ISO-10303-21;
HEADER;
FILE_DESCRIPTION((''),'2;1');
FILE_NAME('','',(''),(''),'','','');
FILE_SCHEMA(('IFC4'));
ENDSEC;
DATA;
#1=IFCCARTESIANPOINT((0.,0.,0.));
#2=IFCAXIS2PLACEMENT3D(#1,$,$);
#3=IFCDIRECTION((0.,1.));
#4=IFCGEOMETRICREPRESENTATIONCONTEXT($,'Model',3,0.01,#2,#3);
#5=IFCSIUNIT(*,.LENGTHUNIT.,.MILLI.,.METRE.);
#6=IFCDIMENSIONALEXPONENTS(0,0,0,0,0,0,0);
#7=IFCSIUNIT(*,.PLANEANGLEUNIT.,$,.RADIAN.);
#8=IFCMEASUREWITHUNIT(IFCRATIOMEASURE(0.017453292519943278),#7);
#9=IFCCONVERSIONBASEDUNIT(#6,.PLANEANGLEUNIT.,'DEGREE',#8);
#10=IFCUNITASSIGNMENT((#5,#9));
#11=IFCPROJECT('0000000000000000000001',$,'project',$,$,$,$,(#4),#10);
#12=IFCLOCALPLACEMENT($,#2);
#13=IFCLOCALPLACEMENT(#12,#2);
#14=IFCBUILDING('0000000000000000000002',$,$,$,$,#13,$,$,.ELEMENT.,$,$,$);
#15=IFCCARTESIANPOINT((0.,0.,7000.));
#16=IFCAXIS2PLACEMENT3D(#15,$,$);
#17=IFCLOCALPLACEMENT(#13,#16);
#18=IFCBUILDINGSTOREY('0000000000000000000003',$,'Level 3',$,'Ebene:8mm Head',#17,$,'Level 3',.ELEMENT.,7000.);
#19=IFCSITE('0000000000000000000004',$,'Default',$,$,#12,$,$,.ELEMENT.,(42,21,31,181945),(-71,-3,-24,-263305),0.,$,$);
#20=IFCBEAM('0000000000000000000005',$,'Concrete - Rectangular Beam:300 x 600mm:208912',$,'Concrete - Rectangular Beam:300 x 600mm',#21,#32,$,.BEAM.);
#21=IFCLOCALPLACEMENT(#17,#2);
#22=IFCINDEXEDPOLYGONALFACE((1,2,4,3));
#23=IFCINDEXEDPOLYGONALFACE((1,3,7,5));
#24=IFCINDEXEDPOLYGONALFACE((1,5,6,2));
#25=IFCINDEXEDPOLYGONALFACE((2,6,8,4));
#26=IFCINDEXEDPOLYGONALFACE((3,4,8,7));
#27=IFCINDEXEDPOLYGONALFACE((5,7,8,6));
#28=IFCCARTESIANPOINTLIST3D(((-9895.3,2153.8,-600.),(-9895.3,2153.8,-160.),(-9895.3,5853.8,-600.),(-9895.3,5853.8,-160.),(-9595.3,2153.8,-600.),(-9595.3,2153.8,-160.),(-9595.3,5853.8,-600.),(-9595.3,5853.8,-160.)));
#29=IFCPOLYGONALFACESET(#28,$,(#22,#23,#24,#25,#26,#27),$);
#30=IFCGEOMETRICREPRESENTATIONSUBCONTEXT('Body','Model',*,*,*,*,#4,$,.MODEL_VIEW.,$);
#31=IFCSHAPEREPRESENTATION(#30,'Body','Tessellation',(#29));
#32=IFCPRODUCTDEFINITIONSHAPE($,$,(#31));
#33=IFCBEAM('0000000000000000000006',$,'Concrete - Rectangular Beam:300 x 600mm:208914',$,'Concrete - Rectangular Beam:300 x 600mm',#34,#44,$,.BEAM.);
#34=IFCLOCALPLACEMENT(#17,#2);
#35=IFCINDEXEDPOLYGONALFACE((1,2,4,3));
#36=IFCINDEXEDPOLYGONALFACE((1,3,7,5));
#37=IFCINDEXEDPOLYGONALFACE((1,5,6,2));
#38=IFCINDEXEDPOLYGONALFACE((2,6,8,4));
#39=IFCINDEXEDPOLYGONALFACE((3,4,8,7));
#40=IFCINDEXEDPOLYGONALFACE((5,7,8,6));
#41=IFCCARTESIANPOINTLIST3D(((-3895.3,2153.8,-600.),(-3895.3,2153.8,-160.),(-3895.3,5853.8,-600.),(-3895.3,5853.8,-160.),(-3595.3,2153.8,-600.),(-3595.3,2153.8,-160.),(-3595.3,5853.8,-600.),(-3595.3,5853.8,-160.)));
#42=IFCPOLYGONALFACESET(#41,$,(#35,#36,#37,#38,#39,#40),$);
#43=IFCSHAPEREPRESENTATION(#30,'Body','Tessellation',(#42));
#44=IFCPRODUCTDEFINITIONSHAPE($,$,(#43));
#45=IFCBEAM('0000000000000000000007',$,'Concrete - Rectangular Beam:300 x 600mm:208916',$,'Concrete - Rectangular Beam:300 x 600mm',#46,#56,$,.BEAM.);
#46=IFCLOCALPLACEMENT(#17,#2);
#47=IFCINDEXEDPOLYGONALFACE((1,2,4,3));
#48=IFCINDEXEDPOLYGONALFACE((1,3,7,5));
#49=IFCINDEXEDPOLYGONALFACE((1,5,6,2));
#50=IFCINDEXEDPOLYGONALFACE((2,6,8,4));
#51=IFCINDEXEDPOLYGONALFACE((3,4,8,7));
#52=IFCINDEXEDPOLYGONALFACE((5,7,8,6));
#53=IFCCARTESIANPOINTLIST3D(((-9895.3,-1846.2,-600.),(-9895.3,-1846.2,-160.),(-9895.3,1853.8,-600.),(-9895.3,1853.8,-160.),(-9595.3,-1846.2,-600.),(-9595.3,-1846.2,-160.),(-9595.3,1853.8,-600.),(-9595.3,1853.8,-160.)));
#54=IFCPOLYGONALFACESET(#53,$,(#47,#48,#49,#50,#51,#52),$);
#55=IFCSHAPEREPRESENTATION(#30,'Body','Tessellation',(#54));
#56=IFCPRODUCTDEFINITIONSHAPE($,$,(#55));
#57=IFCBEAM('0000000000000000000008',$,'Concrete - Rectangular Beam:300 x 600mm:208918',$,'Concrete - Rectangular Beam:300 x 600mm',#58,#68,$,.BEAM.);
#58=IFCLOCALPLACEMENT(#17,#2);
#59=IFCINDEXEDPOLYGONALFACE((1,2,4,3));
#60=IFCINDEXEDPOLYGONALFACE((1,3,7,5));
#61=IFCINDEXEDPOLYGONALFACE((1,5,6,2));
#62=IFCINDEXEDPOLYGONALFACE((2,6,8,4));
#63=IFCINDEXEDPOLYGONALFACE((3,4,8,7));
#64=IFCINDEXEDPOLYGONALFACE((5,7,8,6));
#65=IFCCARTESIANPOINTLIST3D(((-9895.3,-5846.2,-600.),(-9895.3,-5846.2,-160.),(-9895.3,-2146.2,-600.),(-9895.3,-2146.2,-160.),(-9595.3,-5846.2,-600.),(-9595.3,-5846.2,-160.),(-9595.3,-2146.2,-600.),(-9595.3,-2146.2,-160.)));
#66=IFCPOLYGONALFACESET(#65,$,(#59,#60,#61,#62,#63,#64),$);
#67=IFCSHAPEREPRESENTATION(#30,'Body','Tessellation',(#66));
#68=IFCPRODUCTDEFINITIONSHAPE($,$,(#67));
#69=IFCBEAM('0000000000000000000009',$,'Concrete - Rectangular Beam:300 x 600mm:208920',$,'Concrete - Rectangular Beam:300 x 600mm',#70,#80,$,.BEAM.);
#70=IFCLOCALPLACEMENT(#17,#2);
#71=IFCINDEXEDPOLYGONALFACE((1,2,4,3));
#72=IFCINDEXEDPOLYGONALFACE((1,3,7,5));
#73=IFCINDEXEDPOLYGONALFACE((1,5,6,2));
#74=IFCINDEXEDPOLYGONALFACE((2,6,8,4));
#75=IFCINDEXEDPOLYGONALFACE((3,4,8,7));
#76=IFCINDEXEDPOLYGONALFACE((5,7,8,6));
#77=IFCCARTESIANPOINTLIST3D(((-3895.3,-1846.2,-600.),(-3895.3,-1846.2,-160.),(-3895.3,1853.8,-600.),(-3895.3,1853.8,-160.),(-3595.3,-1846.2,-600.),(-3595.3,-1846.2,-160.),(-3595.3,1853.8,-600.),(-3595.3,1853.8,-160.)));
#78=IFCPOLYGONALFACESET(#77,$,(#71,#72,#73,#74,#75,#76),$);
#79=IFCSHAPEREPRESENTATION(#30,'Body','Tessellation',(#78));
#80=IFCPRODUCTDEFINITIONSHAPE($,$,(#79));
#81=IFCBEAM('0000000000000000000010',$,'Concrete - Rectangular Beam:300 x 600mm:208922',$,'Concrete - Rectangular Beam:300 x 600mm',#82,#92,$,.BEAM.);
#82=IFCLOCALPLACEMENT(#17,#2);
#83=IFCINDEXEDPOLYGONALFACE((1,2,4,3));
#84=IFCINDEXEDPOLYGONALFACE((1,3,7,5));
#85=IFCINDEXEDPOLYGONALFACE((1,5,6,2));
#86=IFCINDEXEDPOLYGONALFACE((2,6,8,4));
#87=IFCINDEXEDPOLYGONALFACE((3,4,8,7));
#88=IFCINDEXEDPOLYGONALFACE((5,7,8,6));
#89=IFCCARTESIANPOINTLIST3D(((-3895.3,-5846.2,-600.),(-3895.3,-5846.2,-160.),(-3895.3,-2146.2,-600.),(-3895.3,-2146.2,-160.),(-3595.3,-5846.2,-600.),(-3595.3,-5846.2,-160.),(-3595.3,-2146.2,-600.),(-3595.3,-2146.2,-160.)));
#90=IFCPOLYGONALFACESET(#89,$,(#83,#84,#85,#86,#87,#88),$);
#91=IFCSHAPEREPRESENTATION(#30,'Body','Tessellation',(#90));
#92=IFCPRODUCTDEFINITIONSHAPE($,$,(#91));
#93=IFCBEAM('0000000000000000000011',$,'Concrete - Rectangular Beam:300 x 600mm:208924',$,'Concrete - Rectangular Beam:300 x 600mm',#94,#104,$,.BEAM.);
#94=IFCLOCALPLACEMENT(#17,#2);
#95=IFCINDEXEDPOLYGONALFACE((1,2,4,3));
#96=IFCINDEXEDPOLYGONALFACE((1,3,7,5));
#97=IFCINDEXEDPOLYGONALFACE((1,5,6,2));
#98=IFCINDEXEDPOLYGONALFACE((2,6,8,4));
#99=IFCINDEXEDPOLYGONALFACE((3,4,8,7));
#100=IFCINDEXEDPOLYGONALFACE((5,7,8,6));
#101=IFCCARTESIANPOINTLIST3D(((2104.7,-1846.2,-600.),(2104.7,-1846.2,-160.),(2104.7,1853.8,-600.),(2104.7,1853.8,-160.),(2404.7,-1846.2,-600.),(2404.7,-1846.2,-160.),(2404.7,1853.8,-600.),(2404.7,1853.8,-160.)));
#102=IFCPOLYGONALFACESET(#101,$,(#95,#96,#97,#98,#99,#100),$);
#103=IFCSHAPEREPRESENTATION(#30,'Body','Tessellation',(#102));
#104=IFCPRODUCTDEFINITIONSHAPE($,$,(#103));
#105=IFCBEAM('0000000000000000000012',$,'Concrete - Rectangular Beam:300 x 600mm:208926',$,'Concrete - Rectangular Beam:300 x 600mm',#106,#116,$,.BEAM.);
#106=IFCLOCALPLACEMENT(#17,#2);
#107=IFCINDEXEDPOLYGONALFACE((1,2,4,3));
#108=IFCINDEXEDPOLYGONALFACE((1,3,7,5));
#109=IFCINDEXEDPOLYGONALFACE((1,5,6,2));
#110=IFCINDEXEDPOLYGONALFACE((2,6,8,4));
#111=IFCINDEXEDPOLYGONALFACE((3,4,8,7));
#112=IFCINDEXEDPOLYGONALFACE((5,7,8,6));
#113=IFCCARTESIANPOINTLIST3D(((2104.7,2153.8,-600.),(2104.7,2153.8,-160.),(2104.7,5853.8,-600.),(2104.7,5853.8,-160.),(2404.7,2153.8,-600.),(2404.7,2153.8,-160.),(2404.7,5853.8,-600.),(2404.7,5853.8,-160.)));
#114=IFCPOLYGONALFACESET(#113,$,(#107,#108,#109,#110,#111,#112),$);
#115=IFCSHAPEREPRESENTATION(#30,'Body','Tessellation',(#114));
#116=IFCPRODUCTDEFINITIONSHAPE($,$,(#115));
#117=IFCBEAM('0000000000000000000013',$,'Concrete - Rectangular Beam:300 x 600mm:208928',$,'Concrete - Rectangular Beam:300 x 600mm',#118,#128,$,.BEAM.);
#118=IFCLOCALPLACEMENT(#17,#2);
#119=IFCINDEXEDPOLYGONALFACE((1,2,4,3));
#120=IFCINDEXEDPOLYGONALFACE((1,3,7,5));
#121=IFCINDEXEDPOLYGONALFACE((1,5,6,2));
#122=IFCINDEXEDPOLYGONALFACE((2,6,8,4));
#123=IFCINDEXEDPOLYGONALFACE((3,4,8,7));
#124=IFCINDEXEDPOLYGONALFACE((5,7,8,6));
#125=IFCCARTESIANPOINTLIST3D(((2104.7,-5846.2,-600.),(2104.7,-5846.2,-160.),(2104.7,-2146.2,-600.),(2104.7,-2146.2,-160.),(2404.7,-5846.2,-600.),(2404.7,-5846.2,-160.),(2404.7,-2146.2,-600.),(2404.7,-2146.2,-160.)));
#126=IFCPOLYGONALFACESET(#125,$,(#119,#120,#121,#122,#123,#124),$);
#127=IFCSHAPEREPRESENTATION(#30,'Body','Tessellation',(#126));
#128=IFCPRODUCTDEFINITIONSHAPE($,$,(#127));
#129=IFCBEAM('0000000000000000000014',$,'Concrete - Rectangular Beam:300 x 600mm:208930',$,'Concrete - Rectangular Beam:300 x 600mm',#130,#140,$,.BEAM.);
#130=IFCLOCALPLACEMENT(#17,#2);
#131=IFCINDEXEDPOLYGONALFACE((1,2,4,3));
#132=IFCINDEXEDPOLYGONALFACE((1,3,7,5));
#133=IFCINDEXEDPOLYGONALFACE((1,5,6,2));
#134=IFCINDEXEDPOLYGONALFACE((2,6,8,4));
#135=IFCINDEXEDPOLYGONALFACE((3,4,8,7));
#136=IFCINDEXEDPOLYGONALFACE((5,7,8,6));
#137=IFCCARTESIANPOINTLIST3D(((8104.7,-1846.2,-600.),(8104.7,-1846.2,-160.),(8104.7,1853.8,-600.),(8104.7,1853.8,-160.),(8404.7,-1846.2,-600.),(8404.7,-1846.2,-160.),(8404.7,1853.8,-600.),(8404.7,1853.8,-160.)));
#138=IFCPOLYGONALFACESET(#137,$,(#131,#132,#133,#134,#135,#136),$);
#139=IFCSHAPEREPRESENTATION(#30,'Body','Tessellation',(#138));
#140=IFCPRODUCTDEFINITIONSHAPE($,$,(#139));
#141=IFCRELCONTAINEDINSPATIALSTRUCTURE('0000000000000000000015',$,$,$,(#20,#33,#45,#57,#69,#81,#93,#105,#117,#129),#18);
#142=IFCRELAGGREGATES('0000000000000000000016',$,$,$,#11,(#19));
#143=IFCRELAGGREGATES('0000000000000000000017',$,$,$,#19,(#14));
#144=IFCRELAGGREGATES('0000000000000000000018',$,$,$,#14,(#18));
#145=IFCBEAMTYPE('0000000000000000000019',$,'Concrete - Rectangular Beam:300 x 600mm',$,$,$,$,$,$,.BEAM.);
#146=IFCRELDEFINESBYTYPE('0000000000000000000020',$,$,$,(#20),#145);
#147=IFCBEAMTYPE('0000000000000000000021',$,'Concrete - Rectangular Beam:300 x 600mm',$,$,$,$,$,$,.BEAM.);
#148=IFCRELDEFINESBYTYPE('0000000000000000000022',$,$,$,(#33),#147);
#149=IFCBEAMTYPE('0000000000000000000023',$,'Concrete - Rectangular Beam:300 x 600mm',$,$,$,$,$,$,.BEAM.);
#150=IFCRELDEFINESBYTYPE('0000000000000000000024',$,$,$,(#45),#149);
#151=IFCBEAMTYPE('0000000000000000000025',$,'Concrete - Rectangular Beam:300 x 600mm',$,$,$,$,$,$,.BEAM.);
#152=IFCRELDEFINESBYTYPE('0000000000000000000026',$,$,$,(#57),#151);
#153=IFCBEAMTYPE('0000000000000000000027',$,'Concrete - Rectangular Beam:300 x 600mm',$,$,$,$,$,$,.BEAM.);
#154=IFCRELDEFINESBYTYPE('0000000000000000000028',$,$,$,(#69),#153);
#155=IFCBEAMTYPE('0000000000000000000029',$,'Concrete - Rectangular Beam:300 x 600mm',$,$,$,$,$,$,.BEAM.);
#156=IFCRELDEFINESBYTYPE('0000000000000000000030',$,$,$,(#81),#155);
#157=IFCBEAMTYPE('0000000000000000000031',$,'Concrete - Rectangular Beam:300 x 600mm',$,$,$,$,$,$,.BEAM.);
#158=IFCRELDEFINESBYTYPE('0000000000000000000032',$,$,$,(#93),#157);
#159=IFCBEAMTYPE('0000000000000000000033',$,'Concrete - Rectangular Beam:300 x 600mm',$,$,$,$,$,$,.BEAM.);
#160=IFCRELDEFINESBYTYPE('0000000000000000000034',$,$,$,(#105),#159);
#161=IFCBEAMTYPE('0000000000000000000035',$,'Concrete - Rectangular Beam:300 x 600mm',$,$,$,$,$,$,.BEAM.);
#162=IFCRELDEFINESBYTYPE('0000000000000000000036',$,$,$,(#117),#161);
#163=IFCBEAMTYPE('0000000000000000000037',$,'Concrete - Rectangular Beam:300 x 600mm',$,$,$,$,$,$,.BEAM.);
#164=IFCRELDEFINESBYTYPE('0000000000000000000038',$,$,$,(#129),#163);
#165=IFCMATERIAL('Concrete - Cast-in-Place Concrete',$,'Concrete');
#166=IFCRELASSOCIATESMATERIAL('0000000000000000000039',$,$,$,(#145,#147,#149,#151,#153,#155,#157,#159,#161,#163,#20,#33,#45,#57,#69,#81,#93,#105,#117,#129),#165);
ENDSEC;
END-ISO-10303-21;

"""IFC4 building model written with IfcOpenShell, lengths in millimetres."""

from ifc_helpers import new_model, entity, si_unit, converted_unit, direction, frame, frame_2d, origin, place, context, subcontext, project, spatial, polyline, segment, composite_curve, rectangle, outline, extrude, source, transform, mapped, material, material_profile, profile_set, profile_usage, type_object, type_shapes, element, save


model = new_model("IFC4")

# Units and contexts
model_context = context("Model", 3, precision=0.01, world=origin(), true_north=direction((0.0, 1.0)))
body_context = subcontext(model_context, "Body", "Model", "MODEL_VIEW")
ifc_project = project(units=[si_unit("LENGTHUNIT", "METRE", prefix="MILLI"), converted_unit("PLANEANGLEUNIT", "DEGREE", entity("IfcRatioMeasure", 0.017453292519943278), si_unit("PLANEANGLEUNIT", "RADIAN"), dimensions=[0, 0, 0, 0, 0, 0, 0])], contexts=[model_context])

# Site, building, storey
site_placement = place(None, origin())
site = spatial("IfcSite", under=ifc_project, at=site_placement, Name="Default", CompositionType="ELEMENT", RefLatitude=(42, 21, 31, 181945), RefLongitude=(-71, -3, -24, -263305), RefElevation=0.0)
building_placement = place(site_placement, origin())
building = spatial("IfcBuilding", under=site, at=building_placement, CompositionType="ELEMENT")
storey_placement = place(building_placement, frame((0.0, 0.0, 7000.0)))
storey = spatial("IfcBuildingStorey", under=building, at=storey_placement, Name="Level 3", ObjectType="Ebene:8mm Head", LongName="Level 3", CompositionType="ELEMENT", Elevation=7000.0)

# Beams
ifc_material_1 = material(Name="Concrete - Cast-in-Place Concrete", Category="Concrete")
ifc_material_profile_1 = material_profile(ifc_material_1, outline(composite_curve([segment(polyline([(-150.0, -300.0, 0.0), (-150.0, 140.0, 0.0)]), True, "CONTINUOUS"), segment(polyline([(-150.0, 140.0, 0.0), (150.0, 140.0, 0.0)]), True, "CONTINUOUS"), segment(polyline([(150.0, 140.0, 0.0), (150.0, -300.0, 0.0)]), True, "CONTINUOUS"), segment(polyline([(150.0, -300.0, 0.0), (-150.0, -300.0, 0.0)]), True, "CONTINUOUS")], self_intersect=False), kind="CURVE"), Name="300 x 600mm")
ifc_material_profile_2 = material_profile(ifc_material_1, outline(composite_curve([segment(polyline([(1850.0, -150.0, -300.0), (1850.0, -150.0, 300.0)]), True, "CONTINUOUS"), segment(polyline([(1850.0, -150.0, 300.0), (-1850.0, -150.0, 300.0)]), True, "CONTINUOUS"), segment(polyline([(-1850.0, -150.0, 300.0), (-1850.0, -150.0, -300.0)]), True, "CONTINUOUS"), segment(polyline([(-1850.0, -150.0, -300.0), (1850.0, -150.0, -300.0)]), True, "CONTINUOUS")], self_intersect=False), kind="CURVE"), Name="300 x 600mm")
ifc_profile_set = profile_set([ifc_material_profile_1, ifc_material_profile_2], Name="300 x 600mm")
ifc_profile_usage_1 = profile_usage(ifc_profile_set, cardinal=8)
beam_type_1 = type_object("IfcBeamType", Name="Concrete - Rectangular Beam:300 x 600mm", PredefinedType="BEAM", material=ifc_profile_set)
shared_shape_1 = source(origin(), body_context, "Body", "SweptSolid", [
    extrude(rectangle(XDim=440.0, YDim=300.0, at=frame_2d((0.0, 0.0), x_axis=(0.0, 1.0))), frame((-9745.3, 5853.8, 6620.0), z_axis=(0.0, -1.0, 0.0), x_axis=(-1.0, 0.0, 0.0)), (0.0, 0.0, 1.0), 3700.0),
])
type_shapes(beam_type_1, [shared_shape_1])
beam_1_placement = place(storey_placement, frame((0.0, 0.0, -7000.0)))
element("IfcBeam", 1, at=beam_1_placement, inside=storey, type_object=beam_type_1, material=ifc_profile_usage_1, Name="Concrete - Rectangular Beam:300 x 600mm:208912", ObjectType="Concrete - Rectangular Beam:300 x 600mm", PredefinedType="BEAM", context=body_context, shape_type="MappedRepresentation", body=[
    mapped(shared_shape_1, transform((0.0, 0.0, 0.0), scale=1.0)),
])
ifc_profile_usage_2 = profile_usage(ifc_profile_set, cardinal=8)
beam_type_2 = type_object("IfcBeamType", Name="Concrete - Rectangular Beam:300 x 600mm", PredefinedType="BEAM", material=ifc_profile_set)
shared_shape_2 = source(origin(), body_context, "Body", "SweptSolid", [
    extrude(rectangle(XDim=440.0, YDim=300.0, at=frame_2d((0.0, 0.0), x_axis=(0.0, 1.0))), frame((-3745.3, 5853.8, 6620.0), z_axis=(0.0, -1.0, 0.0), x_axis=(-1.0, 0.0, 0.0)), (0.0, 0.0, 1.0), 3700.0),
])
type_shapes(beam_type_2, [shared_shape_2])
beam_2_placement = place(storey_placement, frame((0.0, 0.0, -7000.0)))
element("IfcBeam", 2, at=beam_2_placement, inside=storey, type_object=beam_type_2, material=ifc_profile_usage_2, Name="Concrete - Rectangular Beam:300 x 600mm:208914", ObjectType="Concrete - Rectangular Beam:300 x 600mm", PredefinedType="BEAM", context=body_context, shape_type="MappedRepresentation", body=[
    mapped(shared_shape_2, transform((0.0, 0.0, 0.0), scale=1.0)),
])
ifc_profile_usage_3 = profile_usage(ifc_profile_set, cardinal=8)
beam_type_3 = type_object("IfcBeamType", Name="Concrete - Rectangular Beam:300 x 600mm", PredefinedType="BEAM", material=ifc_profile_set)
shared_shape_3 = source(origin(), body_context, "Body", "SweptSolid", [
    extrude(rectangle(XDim=440.0, YDim=300.0, at=frame_2d((0.0, 0.0), x_axis=(0.0, 1.0))), frame((-9745.3, 1853.8, 6620.0), z_axis=(0.0, -1.0, 0.0), x_axis=(-1.0, 0.0, 0.0)), (0.0, 0.0, 1.0), 3700.0),
])
type_shapes(beam_type_3, [shared_shape_3])
beam_3_placement = place(storey_placement, frame((0.0, 0.0, -7000.0)))
element("IfcBeam", 3, at=beam_3_placement, inside=storey, type_object=beam_type_3, material=ifc_profile_usage_3, Name="Concrete - Rectangular Beam:300 x 600mm:208916", ObjectType="Concrete - Rectangular Beam:300 x 600mm", PredefinedType="BEAM", context=body_context, shape_type="MappedRepresentation", body=[
    mapped(shared_shape_3, transform((0.0, 0.0, 0.0), scale=1.0)),
])
ifc_profile_usage_4 = profile_usage(ifc_profile_set, cardinal=8)
beam_type_4 = type_object("IfcBeamType", Name="Concrete - Rectangular Beam:300 x 600mm", PredefinedType="BEAM", material=ifc_profile_set)
shared_shape_4 = source(origin(), body_context, "Body", "SweptSolid", [
    extrude(rectangle(XDim=440.0, YDim=300.0, at=frame_2d((0.0, 0.0), x_axis=(0.0, 1.0))), frame((-9745.3, -2146.2, 6620.0), z_axis=(0.0, -1.0, 0.0), x_axis=(-1.0, 0.0, 0.0)), (0.0, 0.0, 1.0), 3700.0),
])
type_shapes(beam_type_4, [shared_shape_4])
beam_4_placement = place(storey_placement, frame((0.0, 0.0, -7000.0)))
element("IfcBeam", 4, at=beam_4_placement, inside=storey, type_object=beam_type_4, material=ifc_profile_usage_4, Name="Concrete - Rectangular Beam:300 x 600mm:208918", ObjectType="Concrete - Rectangular Beam:300 x 600mm", PredefinedType="BEAM", context=body_context, shape_type="MappedRepresentation", body=[
    mapped(shared_shape_4, transform((0.0, 0.0, 0.0), scale=1.0)),
])
ifc_profile_usage_5 = profile_usage(ifc_profile_set, cardinal=8)
beam_type_5 = type_object("IfcBeamType", Name="Concrete - Rectangular Beam:300 x 600mm", PredefinedType="BEAM", material=ifc_profile_set)
shared_shape_5 = source(origin(), body_context, "Body", "SweptSolid", [
    extrude(rectangle(XDim=440.0, YDim=300.0, at=frame_2d((0.0, 0.0), x_axis=(0.0, 1.0))), frame((-3745.3, 1853.8, 6620.0), z_axis=(0.0, -1.0, 0.0), x_axis=(-1.0, 0.0, 0.0)), (0.0, 0.0, 1.0), 3700.0),
])
type_shapes(beam_type_5, [shared_shape_5])
beam_5_placement = place(storey_placement, frame((0.0, 0.0, -7000.0)))
element("IfcBeam", 5, at=beam_5_placement, inside=storey, type_object=beam_type_5, material=ifc_profile_usage_5, Name="Concrete - Rectangular Beam:300 x 600mm:208920", ObjectType="Concrete - Rectangular Beam:300 x 600mm", PredefinedType="BEAM", context=body_context, shape_type="MappedRepresentation", body=[
    mapped(shared_shape_5, transform((0.0, 0.0, 0.0), scale=1.0)),
])
ifc_profile_usage_6 = profile_usage(ifc_profile_set, cardinal=8)
beam_type_6 = type_object("IfcBeamType", Name="Concrete - Rectangular Beam:300 x 600mm", PredefinedType="BEAM", material=ifc_profile_set)
shared_shape_6 = source(origin(), body_context, "Body", "SweptSolid", [
    extrude(rectangle(XDim=440.0, YDim=300.0, at=frame_2d((0.0, 0.0), x_axis=(0.0, 1.0))), frame((-3745.3, -2146.2, 6620.0), z_axis=(0.0, -1.0, 0.0), x_axis=(-1.0, 0.0, 0.0)), (0.0, 0.0, 1.0), 3700.0),
])
type_shapes(beam_type_6, [shared_shape_6])
beam_6_placement = place(storey_placement, frame((0.0, 0.0, -7000.0)))
element("IfcBeam", 6, at=beam_6_placement, inside=storey, type_object=beam_type_6, material=ifc_profile_usage_6, Name="Concrete - Rectangular Beam:300 x 600mm:208922", ObjectType="Concrete - Rectangular Beam:300 x 600mm", PredefinedType="BEAM", context=body_context, shape_type="MappedRepresentation", body=[
    mapped(shared_shape_6, transform((0.0, 0.0, 0.0), scale=1.0)),
])
ifc_profile_usage_7 = profile_usage(ifc_profile_set, cardinal=8)
beam_type_7 = type_object("IfcBeamType", Name="Concrete - Rectangular Beam:300 x 600mm", PredefinedType="BEAM", material=ifc_profile_set)
shared_shape_7 = source(origin(), body_context, "Body", "SweptSolid", [
    extrude(rectangle(XDim=440.0, YDim=300.0, at=frame_2d((0.0, 0.0), x_axis=(0.0, 1.0))), frame((2254.7, 1853.8, 6620.0), z_axis=(0.0, -1.0, 0.0), x_axis=(-1.0, 0.0, 0.0)), (0.0, 0.0, 1.0), 3700.0),
])
type_shapes(beam_type_7, [shared_shape_7])
beam_7_placement = place(storey_placement, frame((0.0, 0.0, -7000.0)))
element("IfcBeam", 7, at=beam_7_placement, inside=storey, type_object=beam_type_7, material=ifc_profile_usage_7, Name="Concrete - Rectangular Beam:300 x 600mm:208924", ObjectType="Concrete - Rectangular Beam:300 x 600mm", PredefinedType="BEAM", context=body_context, shape_type="MappedRepresentation", body=[
    mapped(shared_shape_7, transform((0.0, 0.0, 0.0), scale=1.0)),
])
ifc_profile_usage_8 = profile_usage(ifc_profile_set, cardinal=8)
beam_type_8 = type_object("IfcBeamType", Name="Concrete - Rectangular Beam:300 x 600mm", PredefinedType="BEAM", material=ifc_profile_set)
shared_shape_8 = source(origin(), body_context, "Body", "SweptSolid", [
    extrude(rectangle(XDim=440.0, YDim=300.0, at=frame_2d((0.0, 0.0), x_axis=(0.0, 1.0))), frame((2254.7, 5853.8, 6620.0), z_axis=(0.0, -1.0, 0.0), x_axis=(-1.0, 0.0, 0.0)), (0.0, 0.0, 1.0), 3700.0),
])
type_shapes(beam_type_8, [shared_shape_8])
beam_8_placement = place(storey_placement, frame((0.0, 0.0, -7000.0)))
element("IfcBeam", 8, at=beam_8_placement, inside=storey, type_object=beam_type_8, material=ifc_profile_usage_8, Name="Concrete - Rectangular Beam:300 x 600mm:208926", ObjectType="Concrete - Rectangular Beam:300 x 600mm", PredefinedType="BEAM", context=body_context, shape_type="MappedRepresentation", body=[
    mapped(shared_shape_8, transform((0.0, 0.0, 0.0), scale=1.0)),
])
ifc_profile_usage_9 = profile_usage(ifc_profile_set, cardinal=8)
beam_type_9 = type_object("IfcBeamType", Name="Concrete - Rectangular Beam:300 x 600mm", PredefinedType="BEAM", material=ifc_profile_set)
shared_shape_9 = source(origin(), body_context, "Body", "SweptSolid", [
    extrude(rectangle(XDim=440.0, YDim=300.0, at=frame_2d((0.0, 0.0), x_axis=(0.0, 1.0))), frame((2254.7, -2146.2, 6620.0), z_axis=(0.0, -1.0, 0.0), x_axis=(-1.0, 0.0, 0.0)), (0.0, 0.0, 1.0), 3700.0),
])
type_shapes(beam_type_9, [shared_shape_9])
beam_9_placement = place(storey_placement, frame((0.0, 0.0, -7000.0)))
element("IfcBeam", 9, at=beam_9_placement, inside=storey, type_object=beam_type_9, material=ifc_profile_usage_9, Name="Concrete - Rectangular Beam:300 x 600mm:208928", ObjectType="Concrete - Rectangular Beam:300 x 600mm", PredefinedType="BEAM", context=body_context, shape_type="MappedRepresentation", body=[
    mapped(shared_shape_9, transform((0.0, 0.0, 0.0), scale=1.0)),
])
ifc_profile_usage_10 = profile_usage(ifc_profile_set, cardinal=8)
beam_type_10 = type_object("IfcBeamType", Name="Concrete - Rectangular Beam:300 x 600mm", PredefinedType="BEAM", material=ifc_profile_set)
shared_shape_10 = source(origin(), body_context, "Body", "SweptSolid", [
    extrude(rectangle(XDim=440.0, YDim=300.0, at=frame_2d((0.0, 0.0), x_axis=(0.0, 1.0))), frame((8254.7, 1853.8, 6620.0), z_axis=(0.0, -1.0, 0.0), x_axis=(-1.0, 0.0, 0.0)), (0.0, 0.0, 1.0), 3700.0),
])
type_shapes(beam_type_10, [shared_shape_10])
beam_10_placement = place(storey_placement, frame((0.0, 0.0, -7000.0)))
element("IfcBeam", 10, at=beam_10_placement, inside=storey, type_object=beam_type_10, material=ifc_profile_usage_10, Name="Concrete - Rectangular Beam:300 x 600mm:208930", ObjectType="Concrete - Rectangular Beam:300 x 600mm", PredefinedType="BEAM", context=body_context, shape_type="MappedRepresentation", body=[
    mapped(shared_shape_10, transform((0.0, 0.0, 0.0), scale=1.0)),
])

save(model, "model.ifc")
